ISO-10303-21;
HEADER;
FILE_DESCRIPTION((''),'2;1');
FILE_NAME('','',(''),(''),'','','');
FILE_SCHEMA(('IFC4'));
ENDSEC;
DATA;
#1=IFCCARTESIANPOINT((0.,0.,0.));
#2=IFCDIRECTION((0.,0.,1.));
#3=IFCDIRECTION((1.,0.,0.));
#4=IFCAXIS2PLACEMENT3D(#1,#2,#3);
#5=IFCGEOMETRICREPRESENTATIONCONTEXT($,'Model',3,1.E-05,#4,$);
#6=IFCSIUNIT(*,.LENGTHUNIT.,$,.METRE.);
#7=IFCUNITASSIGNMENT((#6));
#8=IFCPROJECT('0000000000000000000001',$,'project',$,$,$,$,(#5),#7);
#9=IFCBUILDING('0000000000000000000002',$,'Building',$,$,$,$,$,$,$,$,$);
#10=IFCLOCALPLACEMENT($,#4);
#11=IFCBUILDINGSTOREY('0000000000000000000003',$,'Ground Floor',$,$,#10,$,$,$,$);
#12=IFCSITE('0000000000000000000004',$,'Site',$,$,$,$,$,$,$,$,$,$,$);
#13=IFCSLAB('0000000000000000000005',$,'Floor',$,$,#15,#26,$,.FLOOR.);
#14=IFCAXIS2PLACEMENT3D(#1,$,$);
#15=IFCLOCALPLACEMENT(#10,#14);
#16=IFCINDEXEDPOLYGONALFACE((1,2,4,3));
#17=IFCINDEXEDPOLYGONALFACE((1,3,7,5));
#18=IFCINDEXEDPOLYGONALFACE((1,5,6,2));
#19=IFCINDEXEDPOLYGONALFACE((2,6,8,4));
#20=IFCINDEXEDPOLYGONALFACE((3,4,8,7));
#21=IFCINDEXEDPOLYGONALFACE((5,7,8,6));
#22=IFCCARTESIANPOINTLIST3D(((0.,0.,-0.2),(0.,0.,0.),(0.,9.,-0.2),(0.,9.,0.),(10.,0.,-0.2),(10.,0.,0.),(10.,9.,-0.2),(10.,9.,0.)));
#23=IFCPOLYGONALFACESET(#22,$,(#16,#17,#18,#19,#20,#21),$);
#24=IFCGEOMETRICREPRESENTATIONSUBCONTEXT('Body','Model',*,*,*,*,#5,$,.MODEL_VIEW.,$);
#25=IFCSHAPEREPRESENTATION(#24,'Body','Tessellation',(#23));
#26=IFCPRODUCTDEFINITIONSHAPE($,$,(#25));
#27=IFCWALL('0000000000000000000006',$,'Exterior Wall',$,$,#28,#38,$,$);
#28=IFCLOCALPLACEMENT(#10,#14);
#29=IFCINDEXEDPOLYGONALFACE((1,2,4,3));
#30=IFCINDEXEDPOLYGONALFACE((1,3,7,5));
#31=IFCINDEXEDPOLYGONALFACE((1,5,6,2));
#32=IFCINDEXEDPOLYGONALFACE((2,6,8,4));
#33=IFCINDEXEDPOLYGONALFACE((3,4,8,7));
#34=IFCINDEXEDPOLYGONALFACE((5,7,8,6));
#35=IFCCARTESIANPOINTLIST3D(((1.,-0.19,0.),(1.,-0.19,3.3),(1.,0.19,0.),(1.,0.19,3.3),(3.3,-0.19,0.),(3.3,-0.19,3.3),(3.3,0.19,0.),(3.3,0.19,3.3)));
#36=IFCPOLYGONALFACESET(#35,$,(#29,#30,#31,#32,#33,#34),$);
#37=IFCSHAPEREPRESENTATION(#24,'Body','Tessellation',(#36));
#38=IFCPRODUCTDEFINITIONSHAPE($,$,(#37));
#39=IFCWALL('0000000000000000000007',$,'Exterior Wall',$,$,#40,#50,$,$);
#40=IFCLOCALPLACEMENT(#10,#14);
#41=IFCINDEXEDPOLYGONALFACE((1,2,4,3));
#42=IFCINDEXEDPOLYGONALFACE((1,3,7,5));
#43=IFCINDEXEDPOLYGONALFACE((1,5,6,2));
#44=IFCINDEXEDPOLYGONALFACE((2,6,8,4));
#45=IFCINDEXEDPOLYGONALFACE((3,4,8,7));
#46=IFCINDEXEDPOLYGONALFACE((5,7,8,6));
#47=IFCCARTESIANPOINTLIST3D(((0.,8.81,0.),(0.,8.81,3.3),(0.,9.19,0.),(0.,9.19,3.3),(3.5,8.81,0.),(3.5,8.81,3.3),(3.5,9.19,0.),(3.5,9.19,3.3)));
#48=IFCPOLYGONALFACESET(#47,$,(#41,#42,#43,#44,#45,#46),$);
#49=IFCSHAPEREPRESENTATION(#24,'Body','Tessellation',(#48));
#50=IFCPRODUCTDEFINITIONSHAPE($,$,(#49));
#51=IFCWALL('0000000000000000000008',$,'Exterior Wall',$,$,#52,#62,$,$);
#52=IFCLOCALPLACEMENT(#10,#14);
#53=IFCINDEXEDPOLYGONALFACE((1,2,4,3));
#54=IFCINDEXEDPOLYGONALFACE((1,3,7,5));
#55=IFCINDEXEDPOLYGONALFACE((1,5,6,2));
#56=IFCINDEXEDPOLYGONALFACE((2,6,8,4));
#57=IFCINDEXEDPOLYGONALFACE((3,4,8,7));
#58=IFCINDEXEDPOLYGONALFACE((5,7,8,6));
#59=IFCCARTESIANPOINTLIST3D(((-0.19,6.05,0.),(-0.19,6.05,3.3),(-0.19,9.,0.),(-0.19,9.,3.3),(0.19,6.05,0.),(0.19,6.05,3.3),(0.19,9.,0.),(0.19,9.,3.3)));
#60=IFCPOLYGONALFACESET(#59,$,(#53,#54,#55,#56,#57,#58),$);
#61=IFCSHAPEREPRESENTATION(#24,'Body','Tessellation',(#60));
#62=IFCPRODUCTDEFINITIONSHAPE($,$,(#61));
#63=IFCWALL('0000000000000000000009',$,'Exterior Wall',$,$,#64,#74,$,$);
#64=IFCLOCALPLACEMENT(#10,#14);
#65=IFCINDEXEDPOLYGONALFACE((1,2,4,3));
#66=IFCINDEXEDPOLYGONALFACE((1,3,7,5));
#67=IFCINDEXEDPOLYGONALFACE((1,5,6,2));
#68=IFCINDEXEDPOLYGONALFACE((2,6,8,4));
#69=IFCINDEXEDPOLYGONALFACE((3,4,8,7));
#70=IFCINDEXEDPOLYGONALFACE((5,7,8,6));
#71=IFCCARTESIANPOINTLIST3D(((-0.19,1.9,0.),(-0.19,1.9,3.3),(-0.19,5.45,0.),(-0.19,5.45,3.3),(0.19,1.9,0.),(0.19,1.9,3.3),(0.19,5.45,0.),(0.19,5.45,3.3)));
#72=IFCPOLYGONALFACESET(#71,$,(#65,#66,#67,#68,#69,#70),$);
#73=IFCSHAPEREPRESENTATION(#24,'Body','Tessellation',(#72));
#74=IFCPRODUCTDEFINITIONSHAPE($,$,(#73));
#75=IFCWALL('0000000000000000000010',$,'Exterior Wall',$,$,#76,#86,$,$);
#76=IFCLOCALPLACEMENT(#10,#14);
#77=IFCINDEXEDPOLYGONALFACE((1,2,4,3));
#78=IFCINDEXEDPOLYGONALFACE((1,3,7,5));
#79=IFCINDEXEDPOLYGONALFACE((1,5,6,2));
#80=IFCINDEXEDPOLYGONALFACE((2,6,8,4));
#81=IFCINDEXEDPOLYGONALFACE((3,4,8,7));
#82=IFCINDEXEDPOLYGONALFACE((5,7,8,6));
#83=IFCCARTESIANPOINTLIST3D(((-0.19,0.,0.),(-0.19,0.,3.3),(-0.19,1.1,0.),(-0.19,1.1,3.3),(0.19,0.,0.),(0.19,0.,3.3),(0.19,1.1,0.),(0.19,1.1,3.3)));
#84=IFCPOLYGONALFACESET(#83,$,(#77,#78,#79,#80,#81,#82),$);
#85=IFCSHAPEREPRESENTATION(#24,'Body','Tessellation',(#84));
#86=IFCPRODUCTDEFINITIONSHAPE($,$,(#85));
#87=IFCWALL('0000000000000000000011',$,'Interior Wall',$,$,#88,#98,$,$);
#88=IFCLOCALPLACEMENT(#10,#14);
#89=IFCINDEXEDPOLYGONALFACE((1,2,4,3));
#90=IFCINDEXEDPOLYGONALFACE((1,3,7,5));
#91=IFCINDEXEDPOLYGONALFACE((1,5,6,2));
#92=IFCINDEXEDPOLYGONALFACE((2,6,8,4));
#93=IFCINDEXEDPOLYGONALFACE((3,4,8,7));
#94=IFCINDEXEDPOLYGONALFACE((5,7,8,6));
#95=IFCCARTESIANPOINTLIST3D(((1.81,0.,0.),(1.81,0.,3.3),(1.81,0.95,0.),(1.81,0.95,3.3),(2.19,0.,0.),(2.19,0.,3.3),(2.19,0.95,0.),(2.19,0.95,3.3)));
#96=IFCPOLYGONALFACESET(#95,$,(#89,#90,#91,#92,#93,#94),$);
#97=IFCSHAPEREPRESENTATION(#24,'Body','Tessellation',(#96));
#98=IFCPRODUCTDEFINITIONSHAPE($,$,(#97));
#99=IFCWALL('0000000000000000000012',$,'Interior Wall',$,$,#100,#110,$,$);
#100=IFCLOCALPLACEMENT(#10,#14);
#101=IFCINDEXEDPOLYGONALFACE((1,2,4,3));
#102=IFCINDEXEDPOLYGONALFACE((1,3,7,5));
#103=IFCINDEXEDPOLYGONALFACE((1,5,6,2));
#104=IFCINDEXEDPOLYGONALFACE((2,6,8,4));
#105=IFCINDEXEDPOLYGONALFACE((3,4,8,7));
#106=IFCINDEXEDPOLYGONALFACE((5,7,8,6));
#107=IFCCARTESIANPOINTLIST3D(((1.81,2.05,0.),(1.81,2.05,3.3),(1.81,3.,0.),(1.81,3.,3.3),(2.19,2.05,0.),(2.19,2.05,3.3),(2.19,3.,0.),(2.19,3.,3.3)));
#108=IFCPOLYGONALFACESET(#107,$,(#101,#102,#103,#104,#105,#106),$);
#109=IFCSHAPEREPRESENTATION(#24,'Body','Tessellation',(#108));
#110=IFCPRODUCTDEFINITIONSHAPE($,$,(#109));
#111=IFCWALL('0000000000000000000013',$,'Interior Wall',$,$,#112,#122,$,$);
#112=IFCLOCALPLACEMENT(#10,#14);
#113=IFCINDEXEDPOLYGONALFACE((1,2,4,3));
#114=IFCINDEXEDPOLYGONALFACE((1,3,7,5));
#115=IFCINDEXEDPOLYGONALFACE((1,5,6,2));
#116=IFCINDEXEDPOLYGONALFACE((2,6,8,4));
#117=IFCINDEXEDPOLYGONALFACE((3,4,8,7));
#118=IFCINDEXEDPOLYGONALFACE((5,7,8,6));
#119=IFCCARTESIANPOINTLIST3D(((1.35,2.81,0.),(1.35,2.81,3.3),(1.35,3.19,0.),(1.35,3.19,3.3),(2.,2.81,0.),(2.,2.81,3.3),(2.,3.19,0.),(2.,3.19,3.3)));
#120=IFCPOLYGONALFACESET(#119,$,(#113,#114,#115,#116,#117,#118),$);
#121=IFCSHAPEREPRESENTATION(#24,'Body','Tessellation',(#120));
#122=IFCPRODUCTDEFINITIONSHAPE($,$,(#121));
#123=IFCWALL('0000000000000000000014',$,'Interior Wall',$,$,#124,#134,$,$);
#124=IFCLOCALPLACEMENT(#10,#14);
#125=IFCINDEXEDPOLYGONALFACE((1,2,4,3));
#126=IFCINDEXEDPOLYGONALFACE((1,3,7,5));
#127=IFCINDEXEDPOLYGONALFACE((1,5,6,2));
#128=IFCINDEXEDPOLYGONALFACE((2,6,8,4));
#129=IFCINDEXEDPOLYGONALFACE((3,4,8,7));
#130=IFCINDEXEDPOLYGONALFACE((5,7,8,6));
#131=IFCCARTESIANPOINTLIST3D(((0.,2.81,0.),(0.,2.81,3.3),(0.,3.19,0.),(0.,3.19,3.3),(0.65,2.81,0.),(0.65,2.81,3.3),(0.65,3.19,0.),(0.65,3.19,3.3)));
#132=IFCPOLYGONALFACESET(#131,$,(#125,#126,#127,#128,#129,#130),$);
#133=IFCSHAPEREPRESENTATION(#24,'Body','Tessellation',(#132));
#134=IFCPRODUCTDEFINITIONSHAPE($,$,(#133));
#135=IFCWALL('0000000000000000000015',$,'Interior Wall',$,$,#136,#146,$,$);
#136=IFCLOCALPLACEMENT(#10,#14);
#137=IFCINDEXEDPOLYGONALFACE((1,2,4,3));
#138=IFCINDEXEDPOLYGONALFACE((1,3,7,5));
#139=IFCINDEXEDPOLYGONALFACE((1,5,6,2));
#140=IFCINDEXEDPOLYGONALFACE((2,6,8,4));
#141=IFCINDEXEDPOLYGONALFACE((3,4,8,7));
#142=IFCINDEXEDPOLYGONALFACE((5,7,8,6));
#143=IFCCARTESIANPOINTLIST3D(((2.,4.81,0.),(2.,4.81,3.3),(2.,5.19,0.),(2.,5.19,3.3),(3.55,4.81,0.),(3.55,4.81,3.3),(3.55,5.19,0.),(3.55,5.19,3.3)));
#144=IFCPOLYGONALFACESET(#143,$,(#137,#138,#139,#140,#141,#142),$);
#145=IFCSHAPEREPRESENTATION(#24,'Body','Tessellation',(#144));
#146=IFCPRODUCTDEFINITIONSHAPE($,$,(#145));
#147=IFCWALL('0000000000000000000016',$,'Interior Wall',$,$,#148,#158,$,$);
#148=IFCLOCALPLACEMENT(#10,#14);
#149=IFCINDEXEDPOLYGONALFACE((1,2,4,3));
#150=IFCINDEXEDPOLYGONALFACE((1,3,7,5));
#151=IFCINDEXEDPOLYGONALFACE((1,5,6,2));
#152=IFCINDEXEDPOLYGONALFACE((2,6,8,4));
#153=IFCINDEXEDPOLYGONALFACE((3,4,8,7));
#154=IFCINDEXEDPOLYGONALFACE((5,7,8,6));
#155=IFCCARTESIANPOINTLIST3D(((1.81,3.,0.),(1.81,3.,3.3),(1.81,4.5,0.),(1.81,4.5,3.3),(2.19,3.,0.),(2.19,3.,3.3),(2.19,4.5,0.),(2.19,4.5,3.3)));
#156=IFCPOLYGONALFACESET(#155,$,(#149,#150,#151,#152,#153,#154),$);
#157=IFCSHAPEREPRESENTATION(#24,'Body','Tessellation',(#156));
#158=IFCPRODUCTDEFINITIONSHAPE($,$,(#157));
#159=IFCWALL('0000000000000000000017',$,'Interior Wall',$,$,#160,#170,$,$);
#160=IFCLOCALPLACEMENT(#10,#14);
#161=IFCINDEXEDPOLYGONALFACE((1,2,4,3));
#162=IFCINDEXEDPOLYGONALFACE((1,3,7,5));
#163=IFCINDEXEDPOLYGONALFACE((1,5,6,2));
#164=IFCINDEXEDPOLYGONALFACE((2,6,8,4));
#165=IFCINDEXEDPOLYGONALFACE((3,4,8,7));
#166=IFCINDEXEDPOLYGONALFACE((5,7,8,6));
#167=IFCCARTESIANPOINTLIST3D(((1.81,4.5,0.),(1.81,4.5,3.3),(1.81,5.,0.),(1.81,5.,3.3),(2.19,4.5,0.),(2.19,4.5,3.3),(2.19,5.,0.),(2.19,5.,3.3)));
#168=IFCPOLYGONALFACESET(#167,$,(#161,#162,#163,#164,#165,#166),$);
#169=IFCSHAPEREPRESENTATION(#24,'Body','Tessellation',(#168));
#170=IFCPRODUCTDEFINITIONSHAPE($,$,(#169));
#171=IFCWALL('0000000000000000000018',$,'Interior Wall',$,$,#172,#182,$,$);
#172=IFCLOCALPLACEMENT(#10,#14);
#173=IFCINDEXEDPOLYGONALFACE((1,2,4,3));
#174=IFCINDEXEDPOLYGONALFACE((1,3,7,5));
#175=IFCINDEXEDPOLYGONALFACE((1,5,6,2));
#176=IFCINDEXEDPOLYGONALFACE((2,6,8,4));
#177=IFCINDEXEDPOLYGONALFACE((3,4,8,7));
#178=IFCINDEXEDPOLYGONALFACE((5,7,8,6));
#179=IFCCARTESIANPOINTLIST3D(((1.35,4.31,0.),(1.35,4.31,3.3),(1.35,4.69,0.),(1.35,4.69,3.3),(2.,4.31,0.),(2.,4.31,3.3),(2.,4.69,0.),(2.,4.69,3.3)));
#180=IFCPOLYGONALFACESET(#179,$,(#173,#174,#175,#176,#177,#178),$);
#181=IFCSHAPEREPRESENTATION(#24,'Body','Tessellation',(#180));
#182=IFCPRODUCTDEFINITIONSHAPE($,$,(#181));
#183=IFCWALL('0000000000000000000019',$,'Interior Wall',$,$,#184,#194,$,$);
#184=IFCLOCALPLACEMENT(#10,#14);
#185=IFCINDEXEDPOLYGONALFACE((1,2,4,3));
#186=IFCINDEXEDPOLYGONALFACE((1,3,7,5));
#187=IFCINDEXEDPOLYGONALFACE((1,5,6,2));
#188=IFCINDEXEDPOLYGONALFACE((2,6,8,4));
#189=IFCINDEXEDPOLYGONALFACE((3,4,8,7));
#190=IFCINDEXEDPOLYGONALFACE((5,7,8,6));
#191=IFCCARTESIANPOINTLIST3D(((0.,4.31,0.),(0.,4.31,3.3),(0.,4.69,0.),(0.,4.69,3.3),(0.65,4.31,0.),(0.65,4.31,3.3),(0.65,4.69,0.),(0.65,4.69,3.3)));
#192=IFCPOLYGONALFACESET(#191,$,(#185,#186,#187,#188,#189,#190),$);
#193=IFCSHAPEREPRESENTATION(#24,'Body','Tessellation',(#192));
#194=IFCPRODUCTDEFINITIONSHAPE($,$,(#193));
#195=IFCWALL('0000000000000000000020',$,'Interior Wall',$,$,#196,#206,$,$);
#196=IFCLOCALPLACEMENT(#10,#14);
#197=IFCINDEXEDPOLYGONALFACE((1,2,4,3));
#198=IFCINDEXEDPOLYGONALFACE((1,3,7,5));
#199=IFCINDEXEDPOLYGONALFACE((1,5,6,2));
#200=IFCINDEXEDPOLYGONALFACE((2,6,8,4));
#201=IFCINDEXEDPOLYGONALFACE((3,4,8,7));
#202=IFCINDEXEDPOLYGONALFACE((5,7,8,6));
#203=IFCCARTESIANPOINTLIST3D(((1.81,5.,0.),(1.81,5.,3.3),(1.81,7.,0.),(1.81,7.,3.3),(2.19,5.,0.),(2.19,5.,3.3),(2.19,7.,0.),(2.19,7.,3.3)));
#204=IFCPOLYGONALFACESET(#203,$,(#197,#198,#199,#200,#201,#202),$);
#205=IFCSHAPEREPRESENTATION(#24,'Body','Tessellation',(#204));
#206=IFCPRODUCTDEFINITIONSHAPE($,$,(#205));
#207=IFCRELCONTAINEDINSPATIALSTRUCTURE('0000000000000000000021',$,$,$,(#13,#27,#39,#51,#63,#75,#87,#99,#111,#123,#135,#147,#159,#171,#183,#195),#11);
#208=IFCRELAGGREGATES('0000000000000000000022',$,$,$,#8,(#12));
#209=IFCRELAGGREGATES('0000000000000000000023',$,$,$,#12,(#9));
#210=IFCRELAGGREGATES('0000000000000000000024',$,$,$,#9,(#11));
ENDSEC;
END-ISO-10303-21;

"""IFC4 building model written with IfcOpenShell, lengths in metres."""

from ifc_helpers import new_model, si_unit, frame, origin_with_axes, place, context, subcontext, project, spatial, indexed_curve, outline, extrude, element, save


model = new_model("IFC4")

# Units and contexts
model_context = context("Model", 3, precision=1e-05, world=origin_with_axes())
body_context = subcontext(model_context, "Body", "Model", "MODEL_VIEW")
ifc_project = project(units=[si_unit("LENGTHUNIT", "METRE")], contexts=[model_context])

# Site, building, storey
site = spatial("IfcSite", under=ifc_project, Name="Site")
building = spatial("IfcBuilding", under=site, Name="Building")
storey_placement = place(None, origin_with_axes())
storey = spatial("IfcBuildingStorey", under=building, at=storey_placement, Name="Ground Floor")

# Slab
slab_placement = place(storey_placement, frame((0.0, 0.0, -0.2), z_axis=(0.0, 0.0, 1.0), x_axis=(1.0, 0.0, 0.0)))
element("IfcSlab", 1, at=slab_placement, inside=storey, Name="Floor", PredefinedType="FLOOR", context=body_context, shape_type="SweptSolid", body=[
    extrude(outline(indexed_curve([(0.0, 0.0), (10.0, 0.0), (10.0, 9.0), (0.0, 9.0)])), None, (0.0, 0.0, 1.0), 0.2),
])

# Walls
wall_1_placement = place(storey_placement, frame((1.0, 0.0, 0.0), z_axis=(0.0, 0.0, 1.0), x_axis=(1.0, 0.0, 0.0)))
element("IfcWall", 2, at=wall_1_placement, inside=storey, Name="Exterior Wall", context=body_context, shape_type="SweptSolid", body=[
    extrude(outline(indexed_curve([(0.0, 0.0), (0.0, 0.38), (2.3, 0.38), (2.3, 0.0), (0.0, 0.0)], self_intersect=False)), frame((0.0, -0.19, 0.0), z_axis=(0.0, 0.0, 1.0), x_axis=(1.0, 0.0, 0.0)), (0.0, 0.0, 1.0), 3.3),
])
wall_2_placement = place(storey_placement, frame((3.5, 9.0, 0.0), z_axis=(0.0, 0.0, 1.0), x_axis=(-1.0, 0.0, 0.0)))
element("IfcWall", 3, at=wall_2_placement, inside=storey, Name="Exterior Wall", context=body_context, shape_type="SweptSolid", body=[
    extrude(outline(indexed_curve([(0.0, 0.0), (0.0, 0.38), (3.5, 0.38), (3.5, 0.0), (0.0, 0.0)], self_intersect=False)), frame((0.0, -0.19, 0.0), z_axis=(0.0, 0.0, 1.0), x_axis=(1.0, 0.0, 0.0)), (0.0, 0.0, 1.0), 3.3),
])
wall_3_placement = place(storey_placement, frame((0.0, 9.0, 0.0), z_axis=(0.0, 0.0, 1.0), x_axis=(0.0, -1.0, 0.0)))
element("IfcWall", 4, at=wall_3_placement, inside=storey, Name="Exterior Wall", context=body_context, shape_type="SweptSolid", body=[
    extrude(outline(indexed_curve([(0.0, 0.0), (0.0, 0.38), (2.95, 0.38), (2.95, 0.0), (0.0, 0.0)], self_intersect=False)), frame((0.0, -0.19, 0.0), z_axis=(0.0, 0.0, 1.0), x_axis=(1.0, 0.0, 0.0)), (0.0, 0.0, 1.0), 3.3),
])
wall_4_placement = place(storey_placement, frame((0.0, 5.45, 0.0), z_axis=(0.0, 0.0, 1.0), x_axis=(0.0, -1.0, 0.0)))
element("IfcWall", 5, at=wall_4_placement, inside=storey, Name="Exterior Wall", context=body_context, shape_type="SweptSolid", body=[
    extrude(outline(indexed_curve([(0.0, 0.0), (0.0, 0.38), (3.55, 0.38), (3.55, 0.0), (0.0, 0.0)], self_intersect=False)), frame((0.0, -0.19, 0.0), z_axis=(0.0, 0.0, 1.0), x_axis=(1.0, 0.0, 0.0)), (0.0, 0.0, 1.0), 3.3),
])
wall_5_placement = place(storey_placement, frame((0.0, 1.1, 0.0), z_axis=(0.0, 0.0, 1.0), x_axis=(0.0, -1.0, 0.0)))
element("IfcWall", 6, at=wall_5_placement, inside=storey, Name="Exterior Wall", context=body_context, shape_type="SweptSolid", body=[
    extrude(outline(indexed_curve([(0.0, 0.0), (0.0, 0.38), (1.1, 0.38), (1.1, 0.0), (0.0, 0.0)], self_intersect=False)), frame((0.0, -0.19, 0.0), z_axis=(0.0, 0.0, 1.0), x_axis=(1.0, 0.0, 0.0)), (0.0, 0.0, 1.0), 3.3),
])
wall_6_placement = place(storey_placement, frame((2.0, 0.0, 0.0), z_axis=(0.0, 0.0, 1.0), x_axis=(0.0, 1.0, 0.0)))
element("IfcWall", 7, at=wall_6_placement, inside=storey, Name="Interior Wall", context=body_context, shape_type="SweptSolid", body=[
    extrude(outline(indexed_curve([(0.0, 0.0), (0.0, 0.38), (0.95, 0.38), (0.95, 0.0), (0.0, 0.0)], self_intersect=False)), frame((0.0, -0.19, 0.0), z_axis=(0.0, 0.0, 1.0), x_axis=(1.0, 0.0, 0.0)), (0.0, 0.0, 1.0), 3.3),
])
wall_7_placement = place(storey_placement, frame((2.0, 2.05, 0.0), z_axis=(0.0, 0.0, 1.0), x_axis=(0.0, 1.0, 0.0)))
element("IfcWall", 8, at=wall_7_placement, inside=storey, Name="Interior Wall", context=body_context, shape_type="SweptSolid", body=[
    extrude(outline(indexed_curve([(0.0, 0.0), (0.0, 0.38), (0.95, 0.38), (0.95, 0.0), (0.0, 0.0)], self_intersect=False)), frame((0.0, -0.19, 0.0), z_axis=(0.0, 0.0, 1.0), x_axis=(1.0, 0.0, 0.0)), (0.0, 0.0, 1.0), 3.3),
])
for number, where, z_axis, x_axis, name in (
    (9, (2.0, 3.0, 0.0), (0.0, 0.0, 1.0), (-1.0, 0.0, 0.0), "Interior Wall"),
    (10, (0.65, 3.0, 0.0), (0.0, 0.0, 1.0), (-1.0, 0.0, 0.0), "Interior Wall"),
):
    element("IfcWall", number, at=place(storey_placement, frame(where, z_axis=z_axis, x_axis=x_axis)), inside=storey, Name=name, context=body_context, shape_type="SweptSolid", body=[
        extrude(outline(indexed_curve([(0.0, 0.0), (0.0, 0.38), (0.65, 0.38), (0.65, 0.0), (0.0, 0.0)], self_intersect=False)), frame((0.0, -0.19, 0.0), z_axis=(0.0, 0.0, 1.0), x_axis=(1.0, 0.0, 0.0)), (0.0, 0.0, 1.0), 3.3),
    ])
wall_8_placement = place(storey_placement, frame((3.55, 5.0, 0.0), z_axis=(0.0, 0.0, 1.0), x_axis=(-1.0, 0.0, 0.0)))
element("IfcWall", 11, at=wall_8_placement, inside=storey, Name="Interior Wall", context=body_context, shape_type="SweptSolid", body=[
    extrude(outline(indexed_curve([(0.0, 0.0), (0.0, 0.38), (1.55, 0.38), (1.55, 0.0), (0.0, 0.0)], self_intersect=False)), frame((0.0, -0.19, 0.0), z_axis=(0.0, 0.0, 1.0), x_axis=(1.0, 0.0, 0.0)), (0.0, 0.0, 1.0), 3.3),
])
wall_9_placement = place(storey_placement, frame((2.0, 4.5, 0.0), z_axis=(0.0, 0.0, 1.0), x_axis=(0.0, -1.0, 0.0)))
element("IfcWall", 12, at=wall_9_placement, inside=storey, Name="Interior Wall", context=body_context, shape_type="SweptSolid", body=[
    extrude(outline(indexed_curve([(0.0, 0.0), (0.0, 0.38), (1.5, 0.38), (1.5, 0.0), (0.0, 0.0)], self_intersect=False)), frame((0.0, -0.19, 0.0), z_axis=(0.0, 0.0, 1.0), x_axis=(1.0, 0.0, 0.0)), (0.0, 0.0, 1.0), 3.3),
])
wall_10_placement = place(storey_placement, frame((2.0, 5.0, 0.0), z_axis=(0.0, 0.0, 1.0), x_axis=(0.0, -1.0, 0.0)))
element("IfcWall", 13, at=wall_10_placement, inside=storey, Name="Interior Wall", context=body_context, shape_type="SweptSolid", body=[
    extrude(outline(indexed_curve([(0.0, 0.0), (0.0, 0.38), (0.5, 0.38), (0.5, 0.0), (0.0, 0.0)], self_intersect=False)), frame((0.0, -0.19, 0.0), z_axis=(0.0, 0.0, 1.0), x_axis=(1.0, 0.0, 0.0)), (0.0, 0.0, 1.0), 3.3),
])
for number, where, z_axis, x_axis, name in (
    (14, (2.0, 4.5, 0.0), (0.0, 0.0, 1.0), (-1.0, 0.0, 0.0), "Interior Wall"),
    (15, (0.65, 4.5, 0.0), (0.0, 0.0, 1.0), (-1.0, 0.0, 0.0), "Interior Wall"),
):
    element("IfcWall", number, at=place(storey_placement, frame(where, z_axis=z_axis, x_axis=x_axis)), inside=storey, Name=name, context=body_context, shape_type="SweptSolid", body=[
        extrude(outline(indexed_curve([(0.0, 0.0), (0.0, 0.38), (0.65, 0.38), (0.65, 0.0), (0.0, 0.0)], self_intersect=False)), frame((0.0, -0.19, 0.0), z_axis=(0.0, 0.0, 1.0), x_axis=(1.0, 0.0, 0.0)), (0.0, 0.0, 1.0), 3.3),
    ])
wall_11_placement = place(storey_placement, frame((2.0, 5.0, 0.0), z_axis=(0.0, 0.0, 1.0), x_axis=(0.0, 1.0, 0.0)))
element("IfcWall", 16, at=wall_11_placement, inside=storey, Name="Interior Wall", context=body_context, shape_type="SweptSolid", body=[
    extrude(outline(indexed_curve([(0.0, 0.0), (0.0, 0.38), (2.0, 0.38), (2.0, 0.0), (0.0, 0.0)], self_intersect=False)), frame((0.0, -0.19, 0.0), z_axis=(0.0, 0.0, 1.0), x_axis=(1.0, 0.0, 0.0)), (0.0, 0.0, 1.0), 3.3),
])

save(model, "model.ifc")
